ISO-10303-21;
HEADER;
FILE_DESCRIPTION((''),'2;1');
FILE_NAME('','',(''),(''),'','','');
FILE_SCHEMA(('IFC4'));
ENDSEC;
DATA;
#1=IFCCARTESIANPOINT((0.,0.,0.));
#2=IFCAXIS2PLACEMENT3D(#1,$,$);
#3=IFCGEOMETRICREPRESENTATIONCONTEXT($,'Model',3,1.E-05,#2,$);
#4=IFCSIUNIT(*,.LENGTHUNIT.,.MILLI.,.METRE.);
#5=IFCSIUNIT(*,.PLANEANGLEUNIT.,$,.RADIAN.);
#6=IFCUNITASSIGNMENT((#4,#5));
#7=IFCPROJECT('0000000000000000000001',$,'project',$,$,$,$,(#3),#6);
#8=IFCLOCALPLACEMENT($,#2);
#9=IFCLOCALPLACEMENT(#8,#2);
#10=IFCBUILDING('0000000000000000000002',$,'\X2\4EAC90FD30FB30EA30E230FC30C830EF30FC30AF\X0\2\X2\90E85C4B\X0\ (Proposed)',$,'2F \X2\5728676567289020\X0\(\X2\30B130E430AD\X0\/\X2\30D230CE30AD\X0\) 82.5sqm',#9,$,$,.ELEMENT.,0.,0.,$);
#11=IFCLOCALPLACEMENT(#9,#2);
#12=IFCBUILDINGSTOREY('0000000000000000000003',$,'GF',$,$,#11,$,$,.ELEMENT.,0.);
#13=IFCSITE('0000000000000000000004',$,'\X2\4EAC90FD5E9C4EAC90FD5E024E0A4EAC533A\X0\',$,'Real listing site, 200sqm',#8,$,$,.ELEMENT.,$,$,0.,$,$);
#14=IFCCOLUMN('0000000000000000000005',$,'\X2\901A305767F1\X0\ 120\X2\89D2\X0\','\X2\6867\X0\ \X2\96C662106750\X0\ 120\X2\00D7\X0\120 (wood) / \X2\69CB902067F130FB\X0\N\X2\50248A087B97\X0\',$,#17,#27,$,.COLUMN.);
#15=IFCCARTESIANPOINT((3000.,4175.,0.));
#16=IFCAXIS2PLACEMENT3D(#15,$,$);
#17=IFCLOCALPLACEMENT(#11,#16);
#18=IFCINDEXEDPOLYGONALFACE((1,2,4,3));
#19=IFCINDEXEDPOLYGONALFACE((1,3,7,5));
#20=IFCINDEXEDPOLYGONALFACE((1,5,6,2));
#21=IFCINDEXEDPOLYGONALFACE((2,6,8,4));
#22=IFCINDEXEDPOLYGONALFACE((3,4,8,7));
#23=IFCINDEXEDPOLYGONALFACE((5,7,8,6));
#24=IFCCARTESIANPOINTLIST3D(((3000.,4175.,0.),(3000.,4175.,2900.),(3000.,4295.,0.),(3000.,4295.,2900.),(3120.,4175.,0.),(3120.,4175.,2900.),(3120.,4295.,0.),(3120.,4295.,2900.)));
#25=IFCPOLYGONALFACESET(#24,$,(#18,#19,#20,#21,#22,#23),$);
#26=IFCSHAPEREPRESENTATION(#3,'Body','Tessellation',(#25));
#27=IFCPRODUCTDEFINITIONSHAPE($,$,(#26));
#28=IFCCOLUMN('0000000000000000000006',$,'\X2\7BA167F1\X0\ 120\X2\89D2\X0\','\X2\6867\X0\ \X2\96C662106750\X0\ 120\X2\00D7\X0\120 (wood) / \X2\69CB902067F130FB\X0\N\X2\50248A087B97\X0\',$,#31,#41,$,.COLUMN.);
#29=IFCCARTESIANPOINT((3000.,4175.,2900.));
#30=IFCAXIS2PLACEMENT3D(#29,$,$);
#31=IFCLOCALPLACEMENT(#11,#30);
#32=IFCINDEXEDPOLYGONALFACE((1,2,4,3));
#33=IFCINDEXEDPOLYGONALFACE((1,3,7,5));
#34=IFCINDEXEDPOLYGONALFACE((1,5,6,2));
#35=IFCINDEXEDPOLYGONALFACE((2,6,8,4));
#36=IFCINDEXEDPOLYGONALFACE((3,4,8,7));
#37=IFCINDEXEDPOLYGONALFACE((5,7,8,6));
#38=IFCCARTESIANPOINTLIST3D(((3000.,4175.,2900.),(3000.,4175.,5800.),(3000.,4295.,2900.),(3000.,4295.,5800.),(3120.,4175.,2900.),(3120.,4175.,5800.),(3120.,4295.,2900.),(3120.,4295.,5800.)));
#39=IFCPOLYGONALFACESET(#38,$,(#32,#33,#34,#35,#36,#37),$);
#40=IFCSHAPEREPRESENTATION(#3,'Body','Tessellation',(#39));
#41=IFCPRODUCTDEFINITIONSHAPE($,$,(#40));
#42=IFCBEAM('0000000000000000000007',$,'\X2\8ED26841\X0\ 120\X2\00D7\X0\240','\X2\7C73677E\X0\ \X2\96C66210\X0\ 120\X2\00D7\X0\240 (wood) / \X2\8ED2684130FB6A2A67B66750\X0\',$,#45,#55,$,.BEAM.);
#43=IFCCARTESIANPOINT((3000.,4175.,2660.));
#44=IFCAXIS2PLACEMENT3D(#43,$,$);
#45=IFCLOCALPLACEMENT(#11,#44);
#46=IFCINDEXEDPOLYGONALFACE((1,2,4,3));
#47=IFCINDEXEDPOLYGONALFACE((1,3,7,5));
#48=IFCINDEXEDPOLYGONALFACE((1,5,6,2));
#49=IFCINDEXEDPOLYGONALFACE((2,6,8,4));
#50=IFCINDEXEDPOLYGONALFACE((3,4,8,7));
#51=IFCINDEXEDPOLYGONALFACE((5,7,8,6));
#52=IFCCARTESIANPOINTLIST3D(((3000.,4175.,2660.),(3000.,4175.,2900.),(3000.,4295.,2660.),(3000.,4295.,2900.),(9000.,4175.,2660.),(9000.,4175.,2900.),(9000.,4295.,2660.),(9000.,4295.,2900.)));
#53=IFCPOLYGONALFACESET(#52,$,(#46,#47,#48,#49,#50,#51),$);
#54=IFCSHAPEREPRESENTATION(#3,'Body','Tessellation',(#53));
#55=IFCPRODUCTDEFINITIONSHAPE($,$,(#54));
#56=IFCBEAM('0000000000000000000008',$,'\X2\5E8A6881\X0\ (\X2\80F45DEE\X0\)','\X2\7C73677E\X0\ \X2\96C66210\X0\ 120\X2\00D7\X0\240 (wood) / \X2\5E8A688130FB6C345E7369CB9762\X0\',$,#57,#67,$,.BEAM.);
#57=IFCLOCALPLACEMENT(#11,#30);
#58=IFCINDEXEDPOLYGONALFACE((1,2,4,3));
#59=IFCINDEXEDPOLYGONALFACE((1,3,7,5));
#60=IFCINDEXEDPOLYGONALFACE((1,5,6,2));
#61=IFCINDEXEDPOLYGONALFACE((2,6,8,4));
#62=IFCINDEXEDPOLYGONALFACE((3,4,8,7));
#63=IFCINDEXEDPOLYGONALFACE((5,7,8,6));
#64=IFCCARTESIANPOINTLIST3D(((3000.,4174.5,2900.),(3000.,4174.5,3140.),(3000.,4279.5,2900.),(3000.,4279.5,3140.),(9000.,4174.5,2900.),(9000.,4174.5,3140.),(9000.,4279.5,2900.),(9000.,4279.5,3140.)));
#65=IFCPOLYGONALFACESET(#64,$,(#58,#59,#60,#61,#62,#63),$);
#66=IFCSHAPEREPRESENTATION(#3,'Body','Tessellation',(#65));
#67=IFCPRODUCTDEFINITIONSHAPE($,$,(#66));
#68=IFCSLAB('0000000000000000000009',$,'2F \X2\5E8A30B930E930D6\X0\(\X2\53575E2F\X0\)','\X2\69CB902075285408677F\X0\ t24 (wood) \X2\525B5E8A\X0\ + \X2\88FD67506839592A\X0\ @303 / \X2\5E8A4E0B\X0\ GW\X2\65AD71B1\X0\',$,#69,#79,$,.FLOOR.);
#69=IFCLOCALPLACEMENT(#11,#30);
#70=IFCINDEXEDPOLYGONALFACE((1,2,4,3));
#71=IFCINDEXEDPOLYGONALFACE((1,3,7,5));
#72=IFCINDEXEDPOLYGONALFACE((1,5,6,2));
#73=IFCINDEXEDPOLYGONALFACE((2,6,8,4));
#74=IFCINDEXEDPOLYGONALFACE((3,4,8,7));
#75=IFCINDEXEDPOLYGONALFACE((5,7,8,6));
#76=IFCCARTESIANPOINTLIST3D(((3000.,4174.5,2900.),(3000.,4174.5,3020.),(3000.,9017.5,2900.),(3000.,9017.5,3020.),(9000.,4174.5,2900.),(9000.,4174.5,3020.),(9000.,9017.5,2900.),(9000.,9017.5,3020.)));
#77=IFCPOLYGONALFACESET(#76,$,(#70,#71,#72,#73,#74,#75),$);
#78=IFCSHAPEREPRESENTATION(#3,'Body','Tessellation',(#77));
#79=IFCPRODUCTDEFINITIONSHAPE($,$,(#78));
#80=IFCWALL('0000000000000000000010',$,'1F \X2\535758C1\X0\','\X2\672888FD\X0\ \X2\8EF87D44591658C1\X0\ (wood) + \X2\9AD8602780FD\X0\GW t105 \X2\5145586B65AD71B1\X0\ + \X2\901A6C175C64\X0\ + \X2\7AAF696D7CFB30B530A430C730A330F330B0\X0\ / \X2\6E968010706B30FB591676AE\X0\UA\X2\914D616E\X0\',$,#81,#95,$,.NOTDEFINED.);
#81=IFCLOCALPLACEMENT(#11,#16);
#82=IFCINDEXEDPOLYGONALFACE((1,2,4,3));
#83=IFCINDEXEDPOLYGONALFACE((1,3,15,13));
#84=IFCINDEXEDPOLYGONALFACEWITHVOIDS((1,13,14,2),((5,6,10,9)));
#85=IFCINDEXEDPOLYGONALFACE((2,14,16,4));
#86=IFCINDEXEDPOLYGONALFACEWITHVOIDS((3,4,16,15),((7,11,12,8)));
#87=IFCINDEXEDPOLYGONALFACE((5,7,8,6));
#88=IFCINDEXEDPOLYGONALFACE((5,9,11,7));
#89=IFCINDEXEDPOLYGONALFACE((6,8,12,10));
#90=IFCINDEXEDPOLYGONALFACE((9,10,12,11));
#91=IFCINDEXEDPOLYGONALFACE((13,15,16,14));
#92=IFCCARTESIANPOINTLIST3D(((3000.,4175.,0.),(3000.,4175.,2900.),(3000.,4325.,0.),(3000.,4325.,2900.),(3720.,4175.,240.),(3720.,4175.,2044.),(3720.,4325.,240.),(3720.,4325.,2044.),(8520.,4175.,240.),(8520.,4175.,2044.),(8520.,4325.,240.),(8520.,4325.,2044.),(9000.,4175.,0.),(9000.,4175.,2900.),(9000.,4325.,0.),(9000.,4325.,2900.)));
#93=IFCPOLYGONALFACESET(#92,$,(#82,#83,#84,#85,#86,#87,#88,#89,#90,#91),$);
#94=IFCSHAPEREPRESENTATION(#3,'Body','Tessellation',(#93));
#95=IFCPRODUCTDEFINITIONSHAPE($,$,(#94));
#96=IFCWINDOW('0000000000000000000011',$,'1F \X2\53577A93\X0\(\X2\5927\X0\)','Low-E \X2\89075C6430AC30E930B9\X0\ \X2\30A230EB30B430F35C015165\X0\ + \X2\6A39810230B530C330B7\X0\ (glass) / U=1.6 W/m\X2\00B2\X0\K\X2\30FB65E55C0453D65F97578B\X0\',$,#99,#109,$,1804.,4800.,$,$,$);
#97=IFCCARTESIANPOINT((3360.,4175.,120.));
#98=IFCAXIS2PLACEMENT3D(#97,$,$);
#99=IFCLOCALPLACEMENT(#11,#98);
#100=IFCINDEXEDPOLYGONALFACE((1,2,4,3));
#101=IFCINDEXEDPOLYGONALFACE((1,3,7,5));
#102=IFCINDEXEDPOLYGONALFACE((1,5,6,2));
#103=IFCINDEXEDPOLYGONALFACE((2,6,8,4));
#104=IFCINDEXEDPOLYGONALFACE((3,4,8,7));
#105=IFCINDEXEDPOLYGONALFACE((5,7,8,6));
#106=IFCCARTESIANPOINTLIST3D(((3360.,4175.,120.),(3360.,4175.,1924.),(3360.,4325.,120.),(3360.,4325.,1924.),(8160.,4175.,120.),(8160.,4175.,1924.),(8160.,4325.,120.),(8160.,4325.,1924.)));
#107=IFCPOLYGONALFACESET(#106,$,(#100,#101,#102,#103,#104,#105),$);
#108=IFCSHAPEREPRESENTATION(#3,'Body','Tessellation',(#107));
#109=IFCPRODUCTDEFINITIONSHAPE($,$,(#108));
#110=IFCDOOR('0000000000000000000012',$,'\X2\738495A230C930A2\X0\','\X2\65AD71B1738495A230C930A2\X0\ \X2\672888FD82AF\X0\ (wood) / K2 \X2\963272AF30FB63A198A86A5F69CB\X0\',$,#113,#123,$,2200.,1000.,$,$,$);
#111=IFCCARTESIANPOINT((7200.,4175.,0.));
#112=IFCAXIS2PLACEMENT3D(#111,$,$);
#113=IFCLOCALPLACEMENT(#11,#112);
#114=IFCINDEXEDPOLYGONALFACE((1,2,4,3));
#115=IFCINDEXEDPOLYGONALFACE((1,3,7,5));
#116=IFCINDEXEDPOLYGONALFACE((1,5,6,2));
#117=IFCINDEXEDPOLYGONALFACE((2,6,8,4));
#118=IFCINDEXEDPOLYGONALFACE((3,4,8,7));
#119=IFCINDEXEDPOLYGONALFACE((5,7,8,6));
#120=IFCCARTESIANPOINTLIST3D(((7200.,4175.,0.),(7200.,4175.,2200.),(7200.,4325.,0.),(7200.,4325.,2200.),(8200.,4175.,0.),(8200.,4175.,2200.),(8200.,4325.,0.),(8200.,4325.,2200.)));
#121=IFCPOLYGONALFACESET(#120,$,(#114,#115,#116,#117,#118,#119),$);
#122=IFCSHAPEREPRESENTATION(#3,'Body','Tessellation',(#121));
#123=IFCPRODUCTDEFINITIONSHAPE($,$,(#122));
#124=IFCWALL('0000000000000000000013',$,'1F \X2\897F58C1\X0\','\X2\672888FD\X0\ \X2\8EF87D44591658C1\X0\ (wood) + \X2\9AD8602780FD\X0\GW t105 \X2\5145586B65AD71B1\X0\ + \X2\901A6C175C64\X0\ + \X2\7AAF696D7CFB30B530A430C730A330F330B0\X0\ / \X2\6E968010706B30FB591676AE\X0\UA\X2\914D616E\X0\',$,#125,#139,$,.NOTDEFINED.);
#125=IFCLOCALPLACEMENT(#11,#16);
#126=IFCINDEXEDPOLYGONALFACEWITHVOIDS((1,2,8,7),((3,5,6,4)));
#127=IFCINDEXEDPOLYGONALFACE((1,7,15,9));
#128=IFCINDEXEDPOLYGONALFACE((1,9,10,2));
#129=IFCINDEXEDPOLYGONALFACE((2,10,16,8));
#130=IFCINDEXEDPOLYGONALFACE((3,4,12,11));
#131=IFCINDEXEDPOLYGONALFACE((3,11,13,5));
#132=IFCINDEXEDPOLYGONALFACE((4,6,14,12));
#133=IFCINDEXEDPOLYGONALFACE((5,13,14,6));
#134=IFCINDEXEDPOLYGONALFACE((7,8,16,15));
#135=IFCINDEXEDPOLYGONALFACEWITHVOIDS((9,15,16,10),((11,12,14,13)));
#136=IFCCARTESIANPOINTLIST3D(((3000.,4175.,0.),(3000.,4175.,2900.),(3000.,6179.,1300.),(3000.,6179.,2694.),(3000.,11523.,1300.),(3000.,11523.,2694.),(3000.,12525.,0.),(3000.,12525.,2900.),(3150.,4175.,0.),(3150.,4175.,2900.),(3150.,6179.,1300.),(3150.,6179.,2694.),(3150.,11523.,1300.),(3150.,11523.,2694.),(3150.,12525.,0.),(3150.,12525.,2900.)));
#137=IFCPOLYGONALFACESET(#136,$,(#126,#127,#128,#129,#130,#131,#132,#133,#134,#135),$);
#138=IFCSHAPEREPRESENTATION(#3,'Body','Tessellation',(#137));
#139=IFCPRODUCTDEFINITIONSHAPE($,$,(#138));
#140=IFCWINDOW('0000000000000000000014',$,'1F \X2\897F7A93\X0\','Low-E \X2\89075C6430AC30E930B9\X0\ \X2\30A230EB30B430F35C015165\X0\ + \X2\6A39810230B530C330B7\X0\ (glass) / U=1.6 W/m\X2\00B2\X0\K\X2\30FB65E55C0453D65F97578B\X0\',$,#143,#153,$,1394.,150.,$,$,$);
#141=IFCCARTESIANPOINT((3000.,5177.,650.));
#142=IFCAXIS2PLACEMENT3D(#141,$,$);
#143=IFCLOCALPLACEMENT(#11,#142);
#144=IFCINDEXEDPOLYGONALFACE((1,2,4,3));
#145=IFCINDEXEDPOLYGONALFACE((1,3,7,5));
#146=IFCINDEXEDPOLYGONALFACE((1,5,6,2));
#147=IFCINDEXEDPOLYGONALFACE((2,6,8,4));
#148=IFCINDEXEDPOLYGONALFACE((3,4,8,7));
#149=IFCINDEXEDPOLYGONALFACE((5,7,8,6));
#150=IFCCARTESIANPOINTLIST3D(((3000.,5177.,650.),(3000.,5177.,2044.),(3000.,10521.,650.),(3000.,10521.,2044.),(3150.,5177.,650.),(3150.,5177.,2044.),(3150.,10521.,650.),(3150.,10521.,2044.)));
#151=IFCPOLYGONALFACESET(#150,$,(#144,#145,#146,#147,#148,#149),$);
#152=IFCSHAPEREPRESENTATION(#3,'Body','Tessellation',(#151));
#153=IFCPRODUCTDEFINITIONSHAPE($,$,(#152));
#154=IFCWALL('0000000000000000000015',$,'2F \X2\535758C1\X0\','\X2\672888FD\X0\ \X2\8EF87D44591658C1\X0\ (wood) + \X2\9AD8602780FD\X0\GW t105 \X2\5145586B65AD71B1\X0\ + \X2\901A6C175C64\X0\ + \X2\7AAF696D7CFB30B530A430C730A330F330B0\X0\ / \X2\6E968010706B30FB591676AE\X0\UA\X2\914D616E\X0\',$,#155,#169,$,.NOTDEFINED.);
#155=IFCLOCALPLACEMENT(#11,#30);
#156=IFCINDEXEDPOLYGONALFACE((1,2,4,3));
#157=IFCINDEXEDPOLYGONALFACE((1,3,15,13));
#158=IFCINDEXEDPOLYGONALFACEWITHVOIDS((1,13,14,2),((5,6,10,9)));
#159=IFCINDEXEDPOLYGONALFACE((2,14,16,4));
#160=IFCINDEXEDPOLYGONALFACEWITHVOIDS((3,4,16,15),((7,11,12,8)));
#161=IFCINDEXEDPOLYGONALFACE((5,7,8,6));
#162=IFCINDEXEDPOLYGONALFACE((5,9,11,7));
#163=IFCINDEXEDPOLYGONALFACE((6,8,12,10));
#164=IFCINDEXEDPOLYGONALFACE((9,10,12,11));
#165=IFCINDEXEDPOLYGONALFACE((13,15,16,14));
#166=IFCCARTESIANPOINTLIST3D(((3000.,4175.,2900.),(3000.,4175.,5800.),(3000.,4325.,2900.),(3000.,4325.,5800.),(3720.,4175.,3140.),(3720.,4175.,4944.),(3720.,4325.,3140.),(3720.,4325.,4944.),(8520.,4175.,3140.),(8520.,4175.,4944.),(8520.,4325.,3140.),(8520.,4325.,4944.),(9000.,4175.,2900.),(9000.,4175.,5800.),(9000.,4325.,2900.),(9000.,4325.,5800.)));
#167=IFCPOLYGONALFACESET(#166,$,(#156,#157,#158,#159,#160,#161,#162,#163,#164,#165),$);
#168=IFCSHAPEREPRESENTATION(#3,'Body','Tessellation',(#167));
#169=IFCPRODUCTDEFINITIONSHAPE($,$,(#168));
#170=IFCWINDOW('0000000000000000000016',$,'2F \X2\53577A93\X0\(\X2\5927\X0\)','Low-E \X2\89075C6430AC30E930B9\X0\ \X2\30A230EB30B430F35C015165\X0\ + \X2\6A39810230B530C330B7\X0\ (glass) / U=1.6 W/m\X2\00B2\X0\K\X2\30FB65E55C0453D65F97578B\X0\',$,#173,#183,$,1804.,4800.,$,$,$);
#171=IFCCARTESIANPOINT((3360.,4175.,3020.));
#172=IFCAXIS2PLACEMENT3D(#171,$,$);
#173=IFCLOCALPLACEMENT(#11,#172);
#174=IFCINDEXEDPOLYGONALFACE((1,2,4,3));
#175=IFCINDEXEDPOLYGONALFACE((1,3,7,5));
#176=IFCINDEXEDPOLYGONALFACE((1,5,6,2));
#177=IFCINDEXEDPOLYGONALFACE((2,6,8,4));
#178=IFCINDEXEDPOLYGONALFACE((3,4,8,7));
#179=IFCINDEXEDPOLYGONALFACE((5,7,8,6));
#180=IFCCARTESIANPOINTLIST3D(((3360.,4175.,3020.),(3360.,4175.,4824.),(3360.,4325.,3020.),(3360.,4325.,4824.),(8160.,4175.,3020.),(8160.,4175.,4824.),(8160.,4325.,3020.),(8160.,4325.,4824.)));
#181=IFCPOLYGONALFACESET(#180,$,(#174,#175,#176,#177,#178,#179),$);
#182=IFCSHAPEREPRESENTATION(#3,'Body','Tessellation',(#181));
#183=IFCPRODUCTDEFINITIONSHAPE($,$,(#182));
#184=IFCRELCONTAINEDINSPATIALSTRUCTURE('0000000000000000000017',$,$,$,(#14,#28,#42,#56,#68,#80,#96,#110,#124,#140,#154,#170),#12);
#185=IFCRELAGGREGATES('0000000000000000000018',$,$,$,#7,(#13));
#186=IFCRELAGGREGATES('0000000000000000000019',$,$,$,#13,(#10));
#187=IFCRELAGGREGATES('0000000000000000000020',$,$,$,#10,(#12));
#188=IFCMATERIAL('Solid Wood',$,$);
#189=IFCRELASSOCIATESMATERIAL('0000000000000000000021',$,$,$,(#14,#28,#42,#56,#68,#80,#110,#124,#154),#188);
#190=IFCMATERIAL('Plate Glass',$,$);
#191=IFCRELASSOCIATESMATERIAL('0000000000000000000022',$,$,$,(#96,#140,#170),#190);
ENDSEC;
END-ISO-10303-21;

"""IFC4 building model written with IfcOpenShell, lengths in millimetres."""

from ifc_helpers import new_model, si_unit, frame, frame_2d, origin, place, context, project, spatial, rectangle, extrude, material, element, fill, save


model = new_model("IFC4")

# Units and contexts
model_context = context("Model", 3, precision=1e-05, world=origin())
ifc_project = project(units=[si_unit("LENGTHUNIT", "METRE", prefix="MILLI"), si_unit("PLANEANGLEUNIT", "RADIAN")], contexts=[model_context])

# Site, building, storey
site_placement = place(None, origin())
site = spatial("IfcSite", under=ifc_project, at=site_placement, Name="京都府京都市上京区", ObjectType="Real listing site, 200sqm", CompositionType="ELEMENT", RefElevation=0.0)
building_placement = place(site_placement, origin())
building = spatial("IfcBuilding", under=site, at=building_placement, Name="京都・リモートワーク2部屋 (Proposed)", ObjectType="2F 在来木造(ケヤキ/ヒノキ) 82.5sqm", CompositionType="ELEMENT", ElevationOfRefHeight=0.0, ElevationOfTerrain=0.0)
storey_placement = place(building_placement, origin())
storey = spatial("IfcBuildingStorey", under=building, at=storey_placement, Name="GF", CompositionType="ELEMENT", Elevation=0.0)

# Columns
ifc_material_1 = material(Name="Solid Wood")
column_1_placement = place(storey_placement, frame((3000.0, 4175.0, 0.0)))
element("IfcColumn", 1, at=column_1_placement, inside=storey, material=ifc_material_1, Name="通し柱 120角", Description="桧 集成材 120×120 (wood) / 構造柱・N値計算", PredefinedType="COLUMN", context=model_context, shape_type="SweptSolid", body=[
    extrude(rectangle(XDim=120.0, YDim=120.0, at=frame_2d((60.0, 60.0))), frame((3000.0, 4175.0, 0.0)), (0.0, 0.0, 1.0), 2900.0),
])
column_2_placement = place(storey_placement, frame((3000.0, 4175.0, 2900.0)))
element("IfcColumn", 2, at=column_2_placement, inside=storey, material=ifc_material_1, Name="管柱 120角", Description="桧 集成材 120×120 (wood) / 構造柱・N値計算", PredefinedType="COLUMN", context=model_context, shape_type="SweptSolid", body=[
    extrude(rectangle(XDim=120.0, YDim=120.0, at=frame_2d((60.0, 60.0))), frame((3000.0, 4175.0, 2900.0)), (0.0, 0.0, 1.0), 2900.0),
])

# Beams
beam_1_placement = place(storey_placement, frame((3000.0, 4175.0, 2660.0)))
element("IfcBeam", 3, at=beam_1_placement, inside=storey, material=ifc_material_1, Name="軒桁 120×240", Description="米松 集成 120×240 (wood) / 軒桁・横架材", PredefinedType="BEAM", context=model_context, shape_type="SweptSolid", body=[
    extrude(rectangle(XDim=6000.0, YDim=120.0, at=frame_2d((3000.0, 60.0))), frame((3000.0, 4175.0, 2660.0)), (0.0, 0.0, 1.0), 240.0),
])
beam_2_placement = place(storey_placement, frame((3000.0, 4175.0, 2900.0)))
element("IfcBeam", 4, at=beam_2_placement, inside=storey, material=ifc_material_1, Name="床梁 (胴差)", Description="米松 集成 120×240 (wood) / 床梁・水平構面", PredefinedType="BEAM", context=model_context, shape_type="SweptSolid", body=[
    extrude(rectangle(XDim=6000.0, YDim=105.0, at=frame_2d((3000.0, 52.0))), frame((3000.0, 4175.0, 2900.0)), (0.0, 0.0, 1.0), 240.0),
])

# Slab
slab_1_placement = place(storey_placement, frame((3000.0, 4175.0, 2900.0)))
element("IfcSlab", 5, at=slab_1_placement, inside=storey, material=ifc_material_1, Name="2F 床スラブ(南帯)", Description="構造用合板 t24 (wood) 剛床 + 製材根太 @303 / 床下 GW断熱", PredefinedType="FLOOR", context=model_context, shape_type="SweptSolid", body=[
    extrude(rectangle(XDim=6000.0, YDim=4843.0, at=frame_2d((3000.0, 2421.0))), frame((3000.0, 4175.0, 2900.0)), (0.0, 0.0, 1.0), 120.0),
])

# Wall, openings, window, door
wall_1_placement = place(storey_placement, frame((3000.0, 4175.0, 0.0)))
wall_1 = element("IfcWall", 6, at=wall_1_placement, inside=storey, material=ifc_material_1, Name="1F 南壁", Description="木製 軸組外壁 (wood) + 高性能GW t105 充填断熱 + 通気層 + 窯業系サイディング / 準耐火・外皮UA配慮", PredefinedType="NOTDEFINED", context=model_context, shape_type="SweptSolid", body=[
    extrude(rectangle(XDim=6000.0, YDim=150.0, at=frame_2d((3000.0, 75.0))), frame((3000.0, 4175.0, 0.0)), (0.0, 0.0, 1.0), 2900.0),
])
opening_1_placement = place(storey_placement, frame((3360.0, 4175.0, 120.0)))
opening_1 = element("IfcOpeningElement", 7, at=opening_1_placement, cuts=wall_1, PredefinedType="NOTDEFINED", context=model_context, shape_type="SweptSolid", body=[
    extrude(rectangle(XDim=4800.0, YDim=150.0, at=frame_2d((2400.0, 75.0))), frame((3360.0, 4175.0, 120.0)), (0.0, 0.0, 1.0), 1804.0),
])
opening_2_placement = place(storey_placement, frame((7200.0, 4175.0, 0.0)))
opening_2 = element("IfcOpeningElement", 8, at=opening_2_placement, cuts=wall_1, PredefinedType="NOTDEFINED", context=model_context, shape_type="SweptSolid", body=[
    extrude(rectangle(XDim=1000.0, YDim=150.0, at=frame_2d((500.0, 75.0))), frame((7200.0, 4175.0, 0.0)), (0.0, 0.0, 1.0), 2200.0),
])
ifc_material_2 = material(Name="Plate Glass")
window_1_placement = place(storey_placement, frame((3360.0, 4175.0, 120.0)))
window_1 = element("IfcWindow", 9, at=window_1_placement, inside=storey, material=ifc_material_2, Name="1F 南窓(大)", Description="Low-E 複層ガラス アルゴン封入 + 樹脂サッシ (glass) / U=1.6 W/m²K・日射取得型", OverallHeight=1804.0, OverallWidth=4800.0, context=model_context, shape_type="SweptSolid", body=[
    extrude(rectangle(XDim=4800.0, YDim=150.0, at=frame_2d((2400.0, 75.0))), frame((3360.0, 4175.0, 120.0)), (0.0, 0.0, 1.0), 1804.0),
])
fill(opening_1, window_1)
door_placement = place(storey_placement, frame((7200.0, 4175.0, 0.0)))
door = element("IfcDoor", 10, at=door_placement, inside=storey, material=ifc_material_1, Name="玄関ドア", Description="断熱玄関ドア 木製芯 (wood) / K2 防犯・採風機構", OverallHeight=2200.0, OverallWidth=1000.0, context=model_context, shape_type="SweptSolid", body=[
    extrude(rectangle(XDim=1000.0, YDim=150.0, at=frame_2d((500.0, 75.0))), frame((7200.0, 4175.0, 0.0)), (0.0, 0.0, 1.0), 2200.0),
])
fill(opening_2, door)

# Walls, openings, windows
wall_2_placement = place(storey_placement, frame((3000.0, 4175.0, 0.0)))
wall_2 = element("IfcWall", 11, at=wall_2_placement, inside=storey, material=ifc_material_1, Name="1F 西壁", Description="木製 軸組外壁 (wood) + 高性能GW t105 充填断熱 + 通気層 + 窯業系サイディング / 準耐火・外皮UA配慮", PredefinedType="NOTDEFINED", context=model_context, shape_type="SweptSolid", body=[
    extrude(rectangle(XDim=150.0, YDim=8350.0, at=frame_2d((75.0, 4175.0))), frame((3000.0, 4175.0, 0.0)), (0.0, 0.0, 1.0), 2900.0),
])
opening_3_placement = place(storey_placement, frame((3000.0, 5177.0, 650.0)))
opening_3 = element("IfcOpeningElement", 12, at=opening_3_placement, cuts=wall_2, PredefinedType="NOTDEFINED", context=model_context, shape_type="SweptSolid", body=[
    extrude(rectangle(XDim=150.0, YDim=5344.0, at=frame_2d((75.0, 2672.0))), frame((3000.0, 5177.0, 650.0)), (0.0, 0.0, 1.0), 1394.0),
])
window_2_placement = place(storey_placement, frame((3000.0, 5177.0, 650.0)))
window_2 = element("IfcWindow", 13, at=window_2_placement, inside=storey, material=ifc_material_2, Name="1F 西窓", Description="Low-E 複層ガラス アルゴン封入 + 樹脂サッシ (glass) / U=1.6 W/m²K・日射取得型", OverallHeight=1394.0, OverallWidth=150.0, context=model_context, shape_type="SweptSolid", body=[
    extrude(rectangle(XDim=150.0, YDim=5344.0, at=frame_2d((75.0, 2672.0))), frame((3000.0, 5177.0, 650.0)), (0.0, 0.0, 1.0), 1394.0),
])
fill(opening_3, window_2)
wall_3_placement = place(storey_placement, frame((3000.0, 4175.0, 2900.0)))
wall_3 = element("IfcWall", 14, at=wall_3_placement, inside=storey, material=ifc_material_1, Name="2F 南壁", Description="木製 軸組外壁 (wood) + 高性能GW t105 充填断熱 + 通気層 + 窯業系サイディング / 準耐火・外皮UA配慮", PredefinedType="NOTDEFINED", context=model_context, shape_type="SweptSolid", body=[
    extrude(rectangle(XDim=6000.0, YDim=150.0, at=frame_2d((3000.0, 75.0))), frame((3000.0, 4175.0, 2900.0)), (0.0, 0.0, 1.0), 2900.0),
])
opening_4_placement = place(storey_placement, frame((3360.0, 4175.0, 3020.0)))
opening_4 = element("IfcOpeningElement", 15, at=opening_4_placement, cuts=wall_3, PredefinedType="NOTDEFINED", context=model_context, shape_type="SweptSolid", body=[
    extrude(rectangle(XDim=4800.0, YDim=150.0, at=frame_2d((2400.0, 75.0))), frame((3360.0, 4175.0, 3020.0)), (0.0, 0.0, 1.0), 1804.0),
])
window_3_placement = place(storey_placement, frame((3360.0, 4175.0, 3020.0)))
window_3 = element("IfcWindow", 16, at=window_3_placement, inside=storey, material=ifc_material_2, Name="2F 南窓(大)", Description="Low-E 複層ガラス アルゴン封入 + 樹脂サッシ (glass) / U=1.6 W/m²K・日射取得型", OverallHeight=1804.0, OverallWidth=4800.0, context=model_context, shape_type="SweptSolid", body=[
    extrude(rectangle(XDim=4800.0, YDim=150.0, at=frame_2d((2400.0, 75.0))), frame((3360.0, 4175.0, 3020.0)), (0.0, 0.0, 1.0), 1804.0),
])
fill(opening_4, window_3)

save(model, "model.ifc")
